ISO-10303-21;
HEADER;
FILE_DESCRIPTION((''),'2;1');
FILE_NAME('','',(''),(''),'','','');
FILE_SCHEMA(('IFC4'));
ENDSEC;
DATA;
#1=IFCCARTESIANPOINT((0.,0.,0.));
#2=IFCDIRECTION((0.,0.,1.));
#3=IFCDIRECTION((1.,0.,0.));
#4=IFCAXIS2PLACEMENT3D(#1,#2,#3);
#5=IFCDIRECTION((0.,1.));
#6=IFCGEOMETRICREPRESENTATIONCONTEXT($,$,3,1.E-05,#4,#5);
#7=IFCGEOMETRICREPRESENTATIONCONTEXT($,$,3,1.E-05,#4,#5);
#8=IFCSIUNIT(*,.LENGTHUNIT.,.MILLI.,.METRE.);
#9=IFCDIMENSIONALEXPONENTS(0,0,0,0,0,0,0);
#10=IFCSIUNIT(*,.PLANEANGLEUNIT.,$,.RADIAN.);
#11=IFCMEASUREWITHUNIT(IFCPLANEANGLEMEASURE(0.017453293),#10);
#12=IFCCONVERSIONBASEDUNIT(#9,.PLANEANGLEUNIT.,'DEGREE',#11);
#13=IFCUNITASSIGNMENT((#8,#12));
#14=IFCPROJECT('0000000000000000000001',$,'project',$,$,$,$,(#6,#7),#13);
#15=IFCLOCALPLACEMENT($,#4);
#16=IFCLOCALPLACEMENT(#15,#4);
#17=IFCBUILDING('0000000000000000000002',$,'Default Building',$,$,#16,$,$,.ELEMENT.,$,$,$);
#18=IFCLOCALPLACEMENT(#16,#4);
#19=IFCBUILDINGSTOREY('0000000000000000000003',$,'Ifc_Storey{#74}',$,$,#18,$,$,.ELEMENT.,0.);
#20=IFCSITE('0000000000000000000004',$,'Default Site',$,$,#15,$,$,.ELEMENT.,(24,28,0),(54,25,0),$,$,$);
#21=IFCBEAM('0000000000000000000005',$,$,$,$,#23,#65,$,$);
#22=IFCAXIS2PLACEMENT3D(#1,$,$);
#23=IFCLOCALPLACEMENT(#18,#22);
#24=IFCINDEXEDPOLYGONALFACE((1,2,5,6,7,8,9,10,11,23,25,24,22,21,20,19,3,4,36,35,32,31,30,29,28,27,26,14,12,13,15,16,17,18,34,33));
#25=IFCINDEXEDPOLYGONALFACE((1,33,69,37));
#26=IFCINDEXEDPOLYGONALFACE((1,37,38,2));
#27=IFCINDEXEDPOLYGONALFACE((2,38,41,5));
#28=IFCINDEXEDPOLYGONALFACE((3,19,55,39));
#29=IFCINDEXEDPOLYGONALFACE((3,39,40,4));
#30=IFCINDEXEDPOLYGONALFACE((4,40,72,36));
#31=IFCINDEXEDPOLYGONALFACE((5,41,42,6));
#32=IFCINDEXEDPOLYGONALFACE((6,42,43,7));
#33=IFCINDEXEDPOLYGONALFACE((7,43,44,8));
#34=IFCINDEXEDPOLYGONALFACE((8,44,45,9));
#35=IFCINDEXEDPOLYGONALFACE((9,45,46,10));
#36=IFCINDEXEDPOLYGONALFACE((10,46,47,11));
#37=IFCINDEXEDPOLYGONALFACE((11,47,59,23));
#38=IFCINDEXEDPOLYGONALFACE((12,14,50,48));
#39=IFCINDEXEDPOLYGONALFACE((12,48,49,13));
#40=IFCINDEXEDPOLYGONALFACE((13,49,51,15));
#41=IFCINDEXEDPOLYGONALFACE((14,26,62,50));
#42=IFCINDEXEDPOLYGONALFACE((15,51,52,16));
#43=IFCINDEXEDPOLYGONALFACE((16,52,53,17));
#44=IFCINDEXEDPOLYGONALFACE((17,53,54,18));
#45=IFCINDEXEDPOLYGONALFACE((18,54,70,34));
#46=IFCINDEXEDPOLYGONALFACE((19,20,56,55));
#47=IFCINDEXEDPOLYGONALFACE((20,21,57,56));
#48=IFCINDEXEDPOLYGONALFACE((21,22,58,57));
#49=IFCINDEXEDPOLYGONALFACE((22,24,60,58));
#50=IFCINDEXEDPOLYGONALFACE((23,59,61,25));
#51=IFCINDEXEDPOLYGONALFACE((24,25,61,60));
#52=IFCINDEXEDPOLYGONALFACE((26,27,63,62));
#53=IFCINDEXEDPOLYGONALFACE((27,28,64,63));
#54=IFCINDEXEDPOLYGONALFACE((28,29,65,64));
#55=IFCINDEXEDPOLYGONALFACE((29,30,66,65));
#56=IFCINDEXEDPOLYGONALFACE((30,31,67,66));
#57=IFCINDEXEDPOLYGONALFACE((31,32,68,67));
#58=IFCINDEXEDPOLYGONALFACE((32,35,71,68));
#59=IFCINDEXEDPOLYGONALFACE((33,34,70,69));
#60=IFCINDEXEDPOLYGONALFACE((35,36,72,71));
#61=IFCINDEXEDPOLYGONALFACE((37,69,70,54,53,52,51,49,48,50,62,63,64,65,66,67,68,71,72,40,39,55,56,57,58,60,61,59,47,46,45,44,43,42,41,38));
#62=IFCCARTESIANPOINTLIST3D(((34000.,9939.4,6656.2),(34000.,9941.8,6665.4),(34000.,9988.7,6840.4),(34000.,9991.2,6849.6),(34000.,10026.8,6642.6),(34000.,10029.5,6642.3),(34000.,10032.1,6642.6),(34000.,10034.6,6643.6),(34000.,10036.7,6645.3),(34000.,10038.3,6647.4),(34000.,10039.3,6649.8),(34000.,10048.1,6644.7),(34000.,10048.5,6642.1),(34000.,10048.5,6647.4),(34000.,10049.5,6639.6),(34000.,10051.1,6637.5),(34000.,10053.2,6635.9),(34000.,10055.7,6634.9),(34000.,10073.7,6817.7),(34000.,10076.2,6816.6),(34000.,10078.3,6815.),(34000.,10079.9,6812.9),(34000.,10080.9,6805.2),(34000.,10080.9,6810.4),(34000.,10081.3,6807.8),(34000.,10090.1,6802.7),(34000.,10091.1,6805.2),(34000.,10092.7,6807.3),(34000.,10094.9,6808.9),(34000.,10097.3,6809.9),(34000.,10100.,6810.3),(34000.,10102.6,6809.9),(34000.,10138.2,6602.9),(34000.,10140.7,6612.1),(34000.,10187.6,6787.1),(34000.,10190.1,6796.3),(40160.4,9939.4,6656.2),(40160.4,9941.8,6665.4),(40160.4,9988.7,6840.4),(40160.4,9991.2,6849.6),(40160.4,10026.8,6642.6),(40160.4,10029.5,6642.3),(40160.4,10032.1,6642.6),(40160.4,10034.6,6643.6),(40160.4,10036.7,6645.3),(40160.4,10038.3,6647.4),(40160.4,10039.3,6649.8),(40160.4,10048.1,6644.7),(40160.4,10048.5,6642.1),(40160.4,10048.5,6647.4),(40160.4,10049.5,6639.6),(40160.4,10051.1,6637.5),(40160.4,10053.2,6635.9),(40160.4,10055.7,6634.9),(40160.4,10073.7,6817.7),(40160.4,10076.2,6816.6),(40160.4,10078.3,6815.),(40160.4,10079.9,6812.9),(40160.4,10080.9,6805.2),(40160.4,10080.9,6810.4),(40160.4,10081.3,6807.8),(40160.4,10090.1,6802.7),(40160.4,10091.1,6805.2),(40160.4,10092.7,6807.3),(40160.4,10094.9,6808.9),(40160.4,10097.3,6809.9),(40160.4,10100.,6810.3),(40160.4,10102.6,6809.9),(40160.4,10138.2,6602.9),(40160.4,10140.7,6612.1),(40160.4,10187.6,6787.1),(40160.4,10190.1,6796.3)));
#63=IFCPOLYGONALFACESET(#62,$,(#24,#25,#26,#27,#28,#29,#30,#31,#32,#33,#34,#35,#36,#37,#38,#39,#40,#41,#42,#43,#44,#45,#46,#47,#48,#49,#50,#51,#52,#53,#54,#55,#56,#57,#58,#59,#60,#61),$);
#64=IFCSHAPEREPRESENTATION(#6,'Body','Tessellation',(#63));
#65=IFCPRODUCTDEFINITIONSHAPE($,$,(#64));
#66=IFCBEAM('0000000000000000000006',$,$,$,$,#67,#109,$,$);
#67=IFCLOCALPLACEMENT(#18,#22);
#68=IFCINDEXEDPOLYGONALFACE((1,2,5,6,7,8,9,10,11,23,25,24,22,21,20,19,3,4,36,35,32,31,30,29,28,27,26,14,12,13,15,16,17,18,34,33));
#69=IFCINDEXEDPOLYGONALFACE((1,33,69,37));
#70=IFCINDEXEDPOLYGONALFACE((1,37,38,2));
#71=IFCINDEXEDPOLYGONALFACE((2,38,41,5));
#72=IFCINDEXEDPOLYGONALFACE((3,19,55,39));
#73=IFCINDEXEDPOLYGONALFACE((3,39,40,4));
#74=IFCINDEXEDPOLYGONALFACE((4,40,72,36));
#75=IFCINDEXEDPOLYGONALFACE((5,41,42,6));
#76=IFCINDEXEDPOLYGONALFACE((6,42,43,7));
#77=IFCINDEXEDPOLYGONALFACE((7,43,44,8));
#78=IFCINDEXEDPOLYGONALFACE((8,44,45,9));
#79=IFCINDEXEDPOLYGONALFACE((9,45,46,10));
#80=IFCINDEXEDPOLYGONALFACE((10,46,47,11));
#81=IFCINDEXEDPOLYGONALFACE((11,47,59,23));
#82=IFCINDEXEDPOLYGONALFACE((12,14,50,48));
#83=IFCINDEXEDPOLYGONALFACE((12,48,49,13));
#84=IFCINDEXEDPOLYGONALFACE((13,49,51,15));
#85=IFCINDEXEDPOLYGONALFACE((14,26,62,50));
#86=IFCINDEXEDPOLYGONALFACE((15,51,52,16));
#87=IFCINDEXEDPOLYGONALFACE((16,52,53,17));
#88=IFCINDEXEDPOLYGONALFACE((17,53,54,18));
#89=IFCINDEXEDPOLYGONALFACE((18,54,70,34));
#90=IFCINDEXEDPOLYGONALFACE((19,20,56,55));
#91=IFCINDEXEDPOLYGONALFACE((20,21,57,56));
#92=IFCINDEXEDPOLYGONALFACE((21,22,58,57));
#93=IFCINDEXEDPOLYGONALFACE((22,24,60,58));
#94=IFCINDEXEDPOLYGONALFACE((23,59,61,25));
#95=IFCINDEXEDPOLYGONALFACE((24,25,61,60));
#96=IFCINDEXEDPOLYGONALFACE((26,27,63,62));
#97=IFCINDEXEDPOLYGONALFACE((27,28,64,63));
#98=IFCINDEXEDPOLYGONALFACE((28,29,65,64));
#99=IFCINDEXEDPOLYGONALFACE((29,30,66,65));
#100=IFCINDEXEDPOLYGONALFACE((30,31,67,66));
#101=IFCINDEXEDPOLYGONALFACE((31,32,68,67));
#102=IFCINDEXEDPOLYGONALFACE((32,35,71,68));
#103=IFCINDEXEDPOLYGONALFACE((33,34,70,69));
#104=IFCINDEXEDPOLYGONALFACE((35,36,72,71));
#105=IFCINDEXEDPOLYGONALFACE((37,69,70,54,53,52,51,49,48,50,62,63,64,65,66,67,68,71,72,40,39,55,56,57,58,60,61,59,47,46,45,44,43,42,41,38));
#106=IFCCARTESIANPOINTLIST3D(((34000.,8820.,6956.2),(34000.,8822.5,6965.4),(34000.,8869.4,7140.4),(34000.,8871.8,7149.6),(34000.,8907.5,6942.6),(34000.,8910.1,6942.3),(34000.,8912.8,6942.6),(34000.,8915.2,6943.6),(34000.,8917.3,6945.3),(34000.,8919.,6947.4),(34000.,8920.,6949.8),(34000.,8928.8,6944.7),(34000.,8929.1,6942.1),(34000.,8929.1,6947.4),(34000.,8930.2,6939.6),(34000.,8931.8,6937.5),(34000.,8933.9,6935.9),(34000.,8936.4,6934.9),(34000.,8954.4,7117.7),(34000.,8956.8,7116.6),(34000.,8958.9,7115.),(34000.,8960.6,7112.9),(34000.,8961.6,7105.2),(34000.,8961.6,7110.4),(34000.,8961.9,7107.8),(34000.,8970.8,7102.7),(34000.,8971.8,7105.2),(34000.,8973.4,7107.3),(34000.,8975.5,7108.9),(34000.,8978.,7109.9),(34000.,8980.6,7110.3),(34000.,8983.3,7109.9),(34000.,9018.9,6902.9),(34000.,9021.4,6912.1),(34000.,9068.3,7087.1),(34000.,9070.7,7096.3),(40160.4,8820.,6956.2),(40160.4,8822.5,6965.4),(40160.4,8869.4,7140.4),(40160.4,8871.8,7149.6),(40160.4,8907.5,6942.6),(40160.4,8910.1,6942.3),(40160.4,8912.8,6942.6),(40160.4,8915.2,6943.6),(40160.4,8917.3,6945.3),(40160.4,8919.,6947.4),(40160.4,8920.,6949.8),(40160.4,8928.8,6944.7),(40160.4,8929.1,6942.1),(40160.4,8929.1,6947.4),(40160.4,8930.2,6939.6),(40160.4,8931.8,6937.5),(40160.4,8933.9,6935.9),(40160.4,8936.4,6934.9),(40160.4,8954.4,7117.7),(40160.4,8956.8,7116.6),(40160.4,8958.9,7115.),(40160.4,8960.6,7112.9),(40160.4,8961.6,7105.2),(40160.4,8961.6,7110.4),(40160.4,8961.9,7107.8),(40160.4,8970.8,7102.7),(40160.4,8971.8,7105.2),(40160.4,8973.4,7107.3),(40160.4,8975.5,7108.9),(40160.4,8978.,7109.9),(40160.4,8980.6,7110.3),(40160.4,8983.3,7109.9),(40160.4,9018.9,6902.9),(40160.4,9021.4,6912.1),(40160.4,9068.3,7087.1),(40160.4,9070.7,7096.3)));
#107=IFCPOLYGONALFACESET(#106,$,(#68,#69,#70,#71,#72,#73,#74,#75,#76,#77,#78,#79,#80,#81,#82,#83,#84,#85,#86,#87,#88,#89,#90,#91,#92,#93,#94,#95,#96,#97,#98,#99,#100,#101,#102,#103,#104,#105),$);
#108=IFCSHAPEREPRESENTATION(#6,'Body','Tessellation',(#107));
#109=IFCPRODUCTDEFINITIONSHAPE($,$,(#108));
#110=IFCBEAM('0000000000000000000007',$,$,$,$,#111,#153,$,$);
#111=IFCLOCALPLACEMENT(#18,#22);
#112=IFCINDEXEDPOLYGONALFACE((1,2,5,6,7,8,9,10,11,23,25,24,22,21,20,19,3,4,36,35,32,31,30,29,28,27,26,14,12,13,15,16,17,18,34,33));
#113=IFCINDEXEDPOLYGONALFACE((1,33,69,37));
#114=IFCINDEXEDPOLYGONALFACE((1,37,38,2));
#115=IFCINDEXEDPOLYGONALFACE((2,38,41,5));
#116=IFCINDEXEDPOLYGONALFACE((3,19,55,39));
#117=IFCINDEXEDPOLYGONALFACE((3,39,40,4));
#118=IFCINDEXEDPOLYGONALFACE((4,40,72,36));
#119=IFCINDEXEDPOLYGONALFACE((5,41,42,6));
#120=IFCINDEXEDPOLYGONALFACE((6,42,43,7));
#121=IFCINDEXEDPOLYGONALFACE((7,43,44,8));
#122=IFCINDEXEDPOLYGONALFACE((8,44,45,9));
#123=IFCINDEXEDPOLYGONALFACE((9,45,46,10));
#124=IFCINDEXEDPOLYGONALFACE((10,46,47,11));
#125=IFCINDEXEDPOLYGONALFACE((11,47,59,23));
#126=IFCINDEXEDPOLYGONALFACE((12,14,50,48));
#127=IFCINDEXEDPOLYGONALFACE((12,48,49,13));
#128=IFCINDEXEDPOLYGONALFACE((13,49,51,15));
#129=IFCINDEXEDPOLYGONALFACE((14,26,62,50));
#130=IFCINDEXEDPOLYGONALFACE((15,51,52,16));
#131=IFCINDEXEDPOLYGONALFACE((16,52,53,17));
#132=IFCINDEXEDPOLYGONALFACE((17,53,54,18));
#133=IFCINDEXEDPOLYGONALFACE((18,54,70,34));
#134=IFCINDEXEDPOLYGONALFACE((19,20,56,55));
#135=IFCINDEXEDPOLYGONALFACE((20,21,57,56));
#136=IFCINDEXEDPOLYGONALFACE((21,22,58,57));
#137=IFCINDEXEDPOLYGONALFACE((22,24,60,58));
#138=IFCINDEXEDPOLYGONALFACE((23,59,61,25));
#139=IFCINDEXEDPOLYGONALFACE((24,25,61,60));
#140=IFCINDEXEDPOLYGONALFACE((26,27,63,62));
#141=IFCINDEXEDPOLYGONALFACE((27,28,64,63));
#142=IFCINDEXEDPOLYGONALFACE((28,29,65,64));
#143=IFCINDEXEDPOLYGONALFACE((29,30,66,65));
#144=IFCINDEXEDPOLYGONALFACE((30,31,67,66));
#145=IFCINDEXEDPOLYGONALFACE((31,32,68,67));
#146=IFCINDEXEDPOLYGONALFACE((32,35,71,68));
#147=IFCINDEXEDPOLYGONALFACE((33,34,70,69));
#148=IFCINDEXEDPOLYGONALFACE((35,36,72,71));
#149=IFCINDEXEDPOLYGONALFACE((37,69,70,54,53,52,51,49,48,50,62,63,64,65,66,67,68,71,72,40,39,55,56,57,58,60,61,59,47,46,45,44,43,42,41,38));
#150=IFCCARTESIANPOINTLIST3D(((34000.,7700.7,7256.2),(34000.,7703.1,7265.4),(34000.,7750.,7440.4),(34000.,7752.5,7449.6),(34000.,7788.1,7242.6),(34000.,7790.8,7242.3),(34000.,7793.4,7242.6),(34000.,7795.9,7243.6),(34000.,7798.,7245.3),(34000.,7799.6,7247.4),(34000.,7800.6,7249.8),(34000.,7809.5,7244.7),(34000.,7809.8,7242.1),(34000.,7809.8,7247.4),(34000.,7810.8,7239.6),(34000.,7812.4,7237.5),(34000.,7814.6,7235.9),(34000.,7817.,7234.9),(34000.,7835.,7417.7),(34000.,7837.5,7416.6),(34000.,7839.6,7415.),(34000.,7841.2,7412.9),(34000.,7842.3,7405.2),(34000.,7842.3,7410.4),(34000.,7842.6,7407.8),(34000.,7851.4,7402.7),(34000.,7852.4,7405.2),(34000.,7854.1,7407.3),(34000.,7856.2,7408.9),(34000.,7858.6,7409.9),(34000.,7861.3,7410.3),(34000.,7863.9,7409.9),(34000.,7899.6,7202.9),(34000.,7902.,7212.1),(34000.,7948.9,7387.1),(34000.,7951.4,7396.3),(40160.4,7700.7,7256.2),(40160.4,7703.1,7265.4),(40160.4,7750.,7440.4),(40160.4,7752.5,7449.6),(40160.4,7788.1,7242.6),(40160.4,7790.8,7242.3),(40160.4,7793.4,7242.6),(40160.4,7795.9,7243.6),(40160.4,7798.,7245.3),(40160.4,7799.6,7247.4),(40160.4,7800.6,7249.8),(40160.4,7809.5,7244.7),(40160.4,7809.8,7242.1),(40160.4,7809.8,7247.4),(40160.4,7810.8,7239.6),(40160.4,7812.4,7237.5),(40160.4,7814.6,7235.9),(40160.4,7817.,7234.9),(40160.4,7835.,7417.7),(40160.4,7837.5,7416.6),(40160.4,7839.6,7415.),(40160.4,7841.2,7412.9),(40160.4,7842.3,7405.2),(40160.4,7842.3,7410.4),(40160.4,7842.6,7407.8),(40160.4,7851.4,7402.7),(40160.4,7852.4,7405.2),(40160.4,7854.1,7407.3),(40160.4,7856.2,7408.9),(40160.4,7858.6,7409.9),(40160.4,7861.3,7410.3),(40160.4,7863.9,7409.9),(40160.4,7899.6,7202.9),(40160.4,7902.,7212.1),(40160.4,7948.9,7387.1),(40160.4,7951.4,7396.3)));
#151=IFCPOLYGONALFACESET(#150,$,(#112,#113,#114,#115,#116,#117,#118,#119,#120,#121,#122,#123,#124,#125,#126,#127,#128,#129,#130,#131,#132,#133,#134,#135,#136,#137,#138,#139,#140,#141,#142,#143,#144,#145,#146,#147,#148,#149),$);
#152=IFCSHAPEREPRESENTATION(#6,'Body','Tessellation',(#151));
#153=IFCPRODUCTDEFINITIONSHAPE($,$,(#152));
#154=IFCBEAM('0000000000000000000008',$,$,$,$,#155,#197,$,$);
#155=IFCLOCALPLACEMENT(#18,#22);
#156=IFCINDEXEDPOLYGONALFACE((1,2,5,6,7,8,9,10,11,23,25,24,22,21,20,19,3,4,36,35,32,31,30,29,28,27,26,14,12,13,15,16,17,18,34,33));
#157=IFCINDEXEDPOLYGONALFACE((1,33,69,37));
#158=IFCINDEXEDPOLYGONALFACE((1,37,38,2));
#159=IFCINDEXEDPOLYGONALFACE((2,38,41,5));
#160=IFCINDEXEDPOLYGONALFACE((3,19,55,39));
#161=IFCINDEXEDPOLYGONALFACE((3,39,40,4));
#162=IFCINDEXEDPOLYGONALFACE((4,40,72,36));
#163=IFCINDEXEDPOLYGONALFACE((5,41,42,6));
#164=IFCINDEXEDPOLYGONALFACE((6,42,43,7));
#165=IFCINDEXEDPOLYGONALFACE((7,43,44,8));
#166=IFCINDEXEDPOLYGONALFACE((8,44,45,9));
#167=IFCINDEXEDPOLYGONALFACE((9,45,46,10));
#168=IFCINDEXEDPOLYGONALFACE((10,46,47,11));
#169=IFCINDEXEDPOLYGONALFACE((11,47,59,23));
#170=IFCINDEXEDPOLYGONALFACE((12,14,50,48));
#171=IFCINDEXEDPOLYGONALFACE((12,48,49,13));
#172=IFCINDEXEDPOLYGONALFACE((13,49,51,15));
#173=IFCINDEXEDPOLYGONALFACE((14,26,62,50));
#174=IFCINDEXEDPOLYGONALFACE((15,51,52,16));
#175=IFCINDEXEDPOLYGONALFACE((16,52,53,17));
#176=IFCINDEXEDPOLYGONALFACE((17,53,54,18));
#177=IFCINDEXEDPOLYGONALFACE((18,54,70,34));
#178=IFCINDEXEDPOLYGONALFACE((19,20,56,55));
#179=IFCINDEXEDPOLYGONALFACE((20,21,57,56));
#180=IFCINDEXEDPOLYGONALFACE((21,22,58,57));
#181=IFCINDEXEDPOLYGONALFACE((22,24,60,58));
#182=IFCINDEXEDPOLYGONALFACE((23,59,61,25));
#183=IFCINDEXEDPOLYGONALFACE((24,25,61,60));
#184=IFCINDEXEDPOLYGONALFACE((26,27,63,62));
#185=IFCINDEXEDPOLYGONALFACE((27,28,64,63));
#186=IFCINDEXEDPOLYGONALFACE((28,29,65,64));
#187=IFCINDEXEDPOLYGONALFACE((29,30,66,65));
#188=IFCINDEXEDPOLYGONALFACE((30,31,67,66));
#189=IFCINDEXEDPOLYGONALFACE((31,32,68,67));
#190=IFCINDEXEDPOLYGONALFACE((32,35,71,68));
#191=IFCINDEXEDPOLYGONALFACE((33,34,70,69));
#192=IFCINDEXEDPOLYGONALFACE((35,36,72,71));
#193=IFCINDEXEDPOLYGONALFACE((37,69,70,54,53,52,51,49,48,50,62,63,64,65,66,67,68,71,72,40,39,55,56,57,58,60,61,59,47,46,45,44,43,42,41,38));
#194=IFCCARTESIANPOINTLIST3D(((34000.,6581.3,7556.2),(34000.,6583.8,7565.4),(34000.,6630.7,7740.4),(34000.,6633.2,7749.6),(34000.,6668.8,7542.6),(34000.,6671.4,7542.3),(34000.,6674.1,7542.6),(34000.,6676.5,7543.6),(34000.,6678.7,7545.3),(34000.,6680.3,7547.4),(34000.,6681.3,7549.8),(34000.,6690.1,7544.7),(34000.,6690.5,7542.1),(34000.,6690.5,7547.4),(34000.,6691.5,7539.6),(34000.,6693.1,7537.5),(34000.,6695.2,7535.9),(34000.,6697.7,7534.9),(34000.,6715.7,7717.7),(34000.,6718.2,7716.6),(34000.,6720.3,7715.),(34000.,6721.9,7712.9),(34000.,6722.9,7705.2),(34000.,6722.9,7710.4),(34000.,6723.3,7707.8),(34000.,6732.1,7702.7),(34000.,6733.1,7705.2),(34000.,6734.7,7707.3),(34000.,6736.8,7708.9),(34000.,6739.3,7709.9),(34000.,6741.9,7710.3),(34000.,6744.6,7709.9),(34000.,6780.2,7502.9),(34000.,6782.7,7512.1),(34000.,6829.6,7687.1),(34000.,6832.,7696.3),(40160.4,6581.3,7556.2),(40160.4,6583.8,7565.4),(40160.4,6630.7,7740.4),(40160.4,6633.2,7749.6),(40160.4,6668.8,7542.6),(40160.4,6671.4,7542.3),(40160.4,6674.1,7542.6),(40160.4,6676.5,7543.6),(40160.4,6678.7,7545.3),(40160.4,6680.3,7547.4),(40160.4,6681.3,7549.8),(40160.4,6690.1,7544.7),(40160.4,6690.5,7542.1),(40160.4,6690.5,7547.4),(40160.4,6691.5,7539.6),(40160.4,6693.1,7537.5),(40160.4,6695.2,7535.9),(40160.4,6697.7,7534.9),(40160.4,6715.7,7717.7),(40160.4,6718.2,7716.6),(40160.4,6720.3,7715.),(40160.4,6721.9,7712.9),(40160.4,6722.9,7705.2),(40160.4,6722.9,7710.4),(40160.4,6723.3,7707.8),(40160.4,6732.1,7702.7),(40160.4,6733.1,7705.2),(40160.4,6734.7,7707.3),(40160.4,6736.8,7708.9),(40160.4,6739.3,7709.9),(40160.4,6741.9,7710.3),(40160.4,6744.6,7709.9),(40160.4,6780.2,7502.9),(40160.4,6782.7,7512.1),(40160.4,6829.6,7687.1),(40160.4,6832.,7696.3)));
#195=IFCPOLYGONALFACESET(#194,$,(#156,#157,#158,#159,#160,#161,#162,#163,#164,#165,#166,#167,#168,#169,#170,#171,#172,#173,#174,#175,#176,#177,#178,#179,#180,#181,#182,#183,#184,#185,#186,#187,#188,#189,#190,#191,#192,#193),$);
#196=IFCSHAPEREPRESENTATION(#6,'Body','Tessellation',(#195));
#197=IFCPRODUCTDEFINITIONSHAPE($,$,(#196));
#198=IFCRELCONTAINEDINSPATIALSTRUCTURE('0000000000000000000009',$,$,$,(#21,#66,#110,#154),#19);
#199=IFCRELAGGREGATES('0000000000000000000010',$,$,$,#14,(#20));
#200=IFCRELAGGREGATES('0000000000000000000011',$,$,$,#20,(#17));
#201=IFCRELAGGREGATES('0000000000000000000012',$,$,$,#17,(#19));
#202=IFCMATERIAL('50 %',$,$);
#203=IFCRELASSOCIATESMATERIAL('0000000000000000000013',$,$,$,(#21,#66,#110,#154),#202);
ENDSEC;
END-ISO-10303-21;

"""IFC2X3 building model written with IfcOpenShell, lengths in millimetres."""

from ifc_helpers import new_model, entity, si_unit, converted_unit, direction, frame, origin_with_axes, origin_2d_with_axis, place, context, project, spatial, i_section, extrude, material, element, save


model = new_model("IFC2X3")

# Units and contexts
context_of_model_1 = context(None, 3, precision=1e-05, world=origin_with_axes(), true_north=direction((0.0, 1.0)))
context_of_model_2 = context(None, 3, precision=1e-05, world=origin_with_axes(), true_north=direction((0.0, 1.0)))
ifc_project = project(units=[si_unit("LENGTHUNIT", "METRE", prefix="MILLI"), converted_unit("PLANEANGLEUNIT", "DEGREE", entity("IfcPlaneAngleMeasure", 0.017453293), si_unit("PLANEANGLEUNIT", "RADIAN"), dimensions=[0, 0, 0, 0, 0, 0, 0])], contexts=[context_of_model_1, context_of_model_2])

# Site, building, storey
site_placement = place(None, origin_with_axes())
site = spatial("IfcSite", under=ifc_project, at=site_placement, Name="Default Site", CompositionType="ELEMENT", RefLatitude=(24, 28, 0), RefLongitude=(54, 25, 0))
building_placement = place(site_placement, origin_with_axes())
building = spatial("IfcBuilding", under=site, at=building_placement, Name="Default Building", CompositionType="ELEMENT")
storey_placement = place(building_placement, origin_with_axes())
storey = spatial("IfcBuildingStorey", under=building, at=storey_placement, Name="Ifc_Storey{#74}", CompositionType="ELEMENT", Elevation=0.0)

# Shared definitions
ifc_material_1 = material(Name="50 %")

# Beams
for number, where, z_axis, x_axis in (
    (1, (34000.0, 10064.7, 6726.3), (0.0, 0.258819, 0.965926), (1.0, 0.0, 0.0)),
    (2, (34000.0, 8945.4, 7026.3), (0.0, 0.258819, 0.965926), (1.0, 0.0, 0.0)),
    (3, (34000.0, 7826.0, 7326.3), (0.0, 0.258819, 0.965926), (1.0, 0.0, 0.0)),
    (4, (34000.0, 6706.7, 7626.3), (0.0, 0.258819, 0.965926), (1.0, 0.0, 0.0)),
):
    element("IfcBeam", number, at=place(storey_placement, frame(where, z_axis=z_axis, x_axis=x_axis)), inside=storey, material=ifc_material_1, context=context_of_model_1, shape_type="SweptSolid", body=[
        extrude(i_section(OverallWidth=205.9, OverallDepth=200.2, WebThickness=9.5, FlangeThickness=9.5, FilletRadius=10.2, at=origin_2d_with_axis()), frame((0.0, 0.0, 0.0), z_axis=(1.0, 0.0, 0.0), x_axis=(0.0, 1.0, 0.0)), (0.0, 0.0, 1.0), 6160.4),
    ])

save(model, "model.ifc")
